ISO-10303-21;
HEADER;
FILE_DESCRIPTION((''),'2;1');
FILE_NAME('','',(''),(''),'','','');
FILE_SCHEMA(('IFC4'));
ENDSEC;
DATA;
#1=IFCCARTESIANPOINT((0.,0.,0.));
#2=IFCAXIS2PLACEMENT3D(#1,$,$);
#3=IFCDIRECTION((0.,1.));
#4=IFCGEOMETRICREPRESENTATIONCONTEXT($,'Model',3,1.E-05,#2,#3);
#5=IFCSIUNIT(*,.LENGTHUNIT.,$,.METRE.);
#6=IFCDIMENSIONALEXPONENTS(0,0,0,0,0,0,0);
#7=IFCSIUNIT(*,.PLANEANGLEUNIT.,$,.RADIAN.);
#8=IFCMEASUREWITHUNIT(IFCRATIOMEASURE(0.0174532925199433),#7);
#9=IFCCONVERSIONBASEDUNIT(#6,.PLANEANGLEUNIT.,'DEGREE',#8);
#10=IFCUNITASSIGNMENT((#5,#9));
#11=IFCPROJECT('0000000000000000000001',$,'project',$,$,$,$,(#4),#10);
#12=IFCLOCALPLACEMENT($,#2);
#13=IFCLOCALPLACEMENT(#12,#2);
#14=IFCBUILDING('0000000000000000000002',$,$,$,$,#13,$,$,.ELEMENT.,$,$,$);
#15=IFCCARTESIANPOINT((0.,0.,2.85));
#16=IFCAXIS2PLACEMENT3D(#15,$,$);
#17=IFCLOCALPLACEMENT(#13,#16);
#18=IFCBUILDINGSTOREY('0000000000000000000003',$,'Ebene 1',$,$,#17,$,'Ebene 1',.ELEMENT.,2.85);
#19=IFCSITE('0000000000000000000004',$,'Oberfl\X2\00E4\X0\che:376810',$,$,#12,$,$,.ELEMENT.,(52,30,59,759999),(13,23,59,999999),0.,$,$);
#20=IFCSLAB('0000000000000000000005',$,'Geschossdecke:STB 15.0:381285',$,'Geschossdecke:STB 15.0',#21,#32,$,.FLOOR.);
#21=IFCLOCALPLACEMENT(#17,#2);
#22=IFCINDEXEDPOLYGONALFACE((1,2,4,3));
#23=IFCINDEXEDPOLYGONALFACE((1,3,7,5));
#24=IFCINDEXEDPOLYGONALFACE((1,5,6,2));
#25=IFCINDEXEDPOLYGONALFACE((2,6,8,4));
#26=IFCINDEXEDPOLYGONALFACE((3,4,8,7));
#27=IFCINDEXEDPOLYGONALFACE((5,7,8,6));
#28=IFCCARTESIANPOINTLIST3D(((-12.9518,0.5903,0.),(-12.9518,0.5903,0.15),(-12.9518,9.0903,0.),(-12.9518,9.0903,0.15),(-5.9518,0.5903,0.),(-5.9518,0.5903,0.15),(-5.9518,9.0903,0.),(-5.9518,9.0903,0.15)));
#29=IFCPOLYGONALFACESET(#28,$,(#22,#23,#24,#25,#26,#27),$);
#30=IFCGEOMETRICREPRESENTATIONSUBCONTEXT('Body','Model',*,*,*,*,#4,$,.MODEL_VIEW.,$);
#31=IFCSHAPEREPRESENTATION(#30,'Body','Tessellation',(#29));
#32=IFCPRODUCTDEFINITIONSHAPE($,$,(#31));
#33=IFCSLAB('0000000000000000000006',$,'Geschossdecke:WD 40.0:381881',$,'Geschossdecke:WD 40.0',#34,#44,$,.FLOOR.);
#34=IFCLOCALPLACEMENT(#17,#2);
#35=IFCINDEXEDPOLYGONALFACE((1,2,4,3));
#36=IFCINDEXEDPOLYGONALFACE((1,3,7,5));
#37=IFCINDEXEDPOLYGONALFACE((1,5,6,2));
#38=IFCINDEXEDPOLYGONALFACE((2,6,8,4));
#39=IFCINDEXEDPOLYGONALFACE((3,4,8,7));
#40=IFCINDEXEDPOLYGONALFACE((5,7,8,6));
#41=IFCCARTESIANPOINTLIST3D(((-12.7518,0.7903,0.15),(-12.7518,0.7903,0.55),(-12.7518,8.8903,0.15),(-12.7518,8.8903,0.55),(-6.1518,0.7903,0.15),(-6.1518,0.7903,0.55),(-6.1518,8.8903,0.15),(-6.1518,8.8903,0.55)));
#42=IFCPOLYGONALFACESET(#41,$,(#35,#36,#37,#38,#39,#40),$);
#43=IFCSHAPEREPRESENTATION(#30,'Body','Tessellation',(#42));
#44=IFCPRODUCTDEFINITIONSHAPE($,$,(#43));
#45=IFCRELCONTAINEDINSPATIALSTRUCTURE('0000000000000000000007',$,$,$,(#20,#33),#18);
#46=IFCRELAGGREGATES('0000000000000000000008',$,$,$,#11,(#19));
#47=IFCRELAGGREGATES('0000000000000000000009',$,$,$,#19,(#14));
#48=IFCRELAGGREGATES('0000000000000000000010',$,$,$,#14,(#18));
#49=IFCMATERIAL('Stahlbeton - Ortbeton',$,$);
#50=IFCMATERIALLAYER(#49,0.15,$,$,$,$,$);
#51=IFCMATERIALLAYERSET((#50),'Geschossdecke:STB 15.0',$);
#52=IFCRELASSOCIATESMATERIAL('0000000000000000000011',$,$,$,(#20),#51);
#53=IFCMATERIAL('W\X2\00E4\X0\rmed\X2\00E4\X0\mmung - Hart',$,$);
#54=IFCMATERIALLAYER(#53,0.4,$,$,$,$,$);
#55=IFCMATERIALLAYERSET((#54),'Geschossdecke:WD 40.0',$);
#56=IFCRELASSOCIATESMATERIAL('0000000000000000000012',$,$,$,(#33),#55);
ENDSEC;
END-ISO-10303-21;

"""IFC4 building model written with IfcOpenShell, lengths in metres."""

from ifc_helpers import new_model, entity, si_unit, converted_unit, direction, frame, frame_2d, origin, place, context, subcontext, project, spatial, rectangle, extrude, material, layer, layer_set, layer_usage, element, save


model = new_model("IFC4")

# Units and contexts
model_context = context("Model", 3, precision=1e-05, world=origin(), true_north=direction((0.0, 1.0)))
body_context = subcontext(model_context, "Body", "Model", "MODEL_VIEW")
ifc_project = project(units=[si_unit("LENGTHUNIT", "METRE"), converted_unit("PLANEANGLEUNIT", "DEGREE", entity("IfcRatioMeasure", 0.0174532925199433), si_unit("PLANEANGLEUNIT", "RADIAN"), dimensions=[0, 0, 0, 0, 0, 0, 0])], contexts=[model_context])

# Site, building, storey
site_placement = place(None, origin())
site = spatial("IfcSite", under=ifc_project, at=site_placement, Name="Oberfläche:376810", CompositionType="ELEMENT", RefLatitude=(52, 30, 59, 759999), RefLongitude=(13, 23, 59, 999999), RefElevation=0.0)
building_placement = place(site_placement, origin())
building = spatial("IfcBuilding", under=site, at=building_placement, CompositionType="ELEMENT")
storey_placement = place(building_placement, frame((0.0, 0.0, 2.85)))
storey = spatial("IfcBuildingStorey", under=building, at=storey_placement, Name="Ebene 1", LongName="Ebene 1", CompositionType="ELEMENT", Elevation=2.85)

# Slabs
ifc_material_1 = material(Name="Stahlbeton - Ortbeton")
ifc_layer_1 = layer(ifc_material_1, 0.15)
ifc_layer_set_1 = layer_set([ifc_layer_1], Name="Geschossdecke:STB 15.0")
ifc_layer_usage_1 = layer_usage(ifc_layer_set_1, "AXIS3", "POSITIVE", 0.0)
slab_1_placement = place(storey_placement, origin())
element("IfcSlab", 1, at=slab_1_placement, inside=storey, material=ifc_layer_usage_1, Name="Geschossdecke:STB 15.0:381285", ObjectType="Geschossdecke:STB 15.0", PredefinedType="FLOOR", context=body_context, shape_type="SweptSolid", body=[
    extrude(rectangle(XDim=8.5, YDim=7.0, at=frame_2d((0.0, 0.0), x_axis=(1.0, 0.0))), frame((-9.4518, 4.8403, 0.15), z_axis=(0.0, 0.0, -1.0), x_axis=(0.0, 1.0, 0.0)), (0.0, 0.0, 1.0), 0.15),
])
ifc_material_2 = material(Name="Wärmedämmung - Hart")
ifc_layer_2 = layer(ifc_material_2, 0.4)
ifc_layer_set_2 = layer_set([ifc_layer_2], Name="Geschossdecke:WD 40.0")
ifc_layer_usage_2 = layer_usage(ifc_layer_set_2, "AXIS3", "POSITIVE", 0.0)
slab_2_placement = place(storey_placement, origin())
element("IfcSlab", 2, at=slab_2_placement, inside=storey, material=ifc_layer_usage_2, Name="Geschossdecke:WD 40.0:381881", ObjectType="Geschossdecke:WD 40.0", PredefinedType="FLOOR", context=body_context, shape_type="SweptSolid", body=[
    extrude(rectangle(XDim=8.1, YDim=6.6, at=frame_2d((0.0, 0.0), x_axis=(1.0, 0.0))), frame((-9.4518, 4.8403, 0.55), z_axis=(0.0, 0.0, -1.0), x_axis=(0.0, 1.0, 0.0)), (0.0, 0.0, 1.0), 0.4),
])

save(model, "model.ifc")
